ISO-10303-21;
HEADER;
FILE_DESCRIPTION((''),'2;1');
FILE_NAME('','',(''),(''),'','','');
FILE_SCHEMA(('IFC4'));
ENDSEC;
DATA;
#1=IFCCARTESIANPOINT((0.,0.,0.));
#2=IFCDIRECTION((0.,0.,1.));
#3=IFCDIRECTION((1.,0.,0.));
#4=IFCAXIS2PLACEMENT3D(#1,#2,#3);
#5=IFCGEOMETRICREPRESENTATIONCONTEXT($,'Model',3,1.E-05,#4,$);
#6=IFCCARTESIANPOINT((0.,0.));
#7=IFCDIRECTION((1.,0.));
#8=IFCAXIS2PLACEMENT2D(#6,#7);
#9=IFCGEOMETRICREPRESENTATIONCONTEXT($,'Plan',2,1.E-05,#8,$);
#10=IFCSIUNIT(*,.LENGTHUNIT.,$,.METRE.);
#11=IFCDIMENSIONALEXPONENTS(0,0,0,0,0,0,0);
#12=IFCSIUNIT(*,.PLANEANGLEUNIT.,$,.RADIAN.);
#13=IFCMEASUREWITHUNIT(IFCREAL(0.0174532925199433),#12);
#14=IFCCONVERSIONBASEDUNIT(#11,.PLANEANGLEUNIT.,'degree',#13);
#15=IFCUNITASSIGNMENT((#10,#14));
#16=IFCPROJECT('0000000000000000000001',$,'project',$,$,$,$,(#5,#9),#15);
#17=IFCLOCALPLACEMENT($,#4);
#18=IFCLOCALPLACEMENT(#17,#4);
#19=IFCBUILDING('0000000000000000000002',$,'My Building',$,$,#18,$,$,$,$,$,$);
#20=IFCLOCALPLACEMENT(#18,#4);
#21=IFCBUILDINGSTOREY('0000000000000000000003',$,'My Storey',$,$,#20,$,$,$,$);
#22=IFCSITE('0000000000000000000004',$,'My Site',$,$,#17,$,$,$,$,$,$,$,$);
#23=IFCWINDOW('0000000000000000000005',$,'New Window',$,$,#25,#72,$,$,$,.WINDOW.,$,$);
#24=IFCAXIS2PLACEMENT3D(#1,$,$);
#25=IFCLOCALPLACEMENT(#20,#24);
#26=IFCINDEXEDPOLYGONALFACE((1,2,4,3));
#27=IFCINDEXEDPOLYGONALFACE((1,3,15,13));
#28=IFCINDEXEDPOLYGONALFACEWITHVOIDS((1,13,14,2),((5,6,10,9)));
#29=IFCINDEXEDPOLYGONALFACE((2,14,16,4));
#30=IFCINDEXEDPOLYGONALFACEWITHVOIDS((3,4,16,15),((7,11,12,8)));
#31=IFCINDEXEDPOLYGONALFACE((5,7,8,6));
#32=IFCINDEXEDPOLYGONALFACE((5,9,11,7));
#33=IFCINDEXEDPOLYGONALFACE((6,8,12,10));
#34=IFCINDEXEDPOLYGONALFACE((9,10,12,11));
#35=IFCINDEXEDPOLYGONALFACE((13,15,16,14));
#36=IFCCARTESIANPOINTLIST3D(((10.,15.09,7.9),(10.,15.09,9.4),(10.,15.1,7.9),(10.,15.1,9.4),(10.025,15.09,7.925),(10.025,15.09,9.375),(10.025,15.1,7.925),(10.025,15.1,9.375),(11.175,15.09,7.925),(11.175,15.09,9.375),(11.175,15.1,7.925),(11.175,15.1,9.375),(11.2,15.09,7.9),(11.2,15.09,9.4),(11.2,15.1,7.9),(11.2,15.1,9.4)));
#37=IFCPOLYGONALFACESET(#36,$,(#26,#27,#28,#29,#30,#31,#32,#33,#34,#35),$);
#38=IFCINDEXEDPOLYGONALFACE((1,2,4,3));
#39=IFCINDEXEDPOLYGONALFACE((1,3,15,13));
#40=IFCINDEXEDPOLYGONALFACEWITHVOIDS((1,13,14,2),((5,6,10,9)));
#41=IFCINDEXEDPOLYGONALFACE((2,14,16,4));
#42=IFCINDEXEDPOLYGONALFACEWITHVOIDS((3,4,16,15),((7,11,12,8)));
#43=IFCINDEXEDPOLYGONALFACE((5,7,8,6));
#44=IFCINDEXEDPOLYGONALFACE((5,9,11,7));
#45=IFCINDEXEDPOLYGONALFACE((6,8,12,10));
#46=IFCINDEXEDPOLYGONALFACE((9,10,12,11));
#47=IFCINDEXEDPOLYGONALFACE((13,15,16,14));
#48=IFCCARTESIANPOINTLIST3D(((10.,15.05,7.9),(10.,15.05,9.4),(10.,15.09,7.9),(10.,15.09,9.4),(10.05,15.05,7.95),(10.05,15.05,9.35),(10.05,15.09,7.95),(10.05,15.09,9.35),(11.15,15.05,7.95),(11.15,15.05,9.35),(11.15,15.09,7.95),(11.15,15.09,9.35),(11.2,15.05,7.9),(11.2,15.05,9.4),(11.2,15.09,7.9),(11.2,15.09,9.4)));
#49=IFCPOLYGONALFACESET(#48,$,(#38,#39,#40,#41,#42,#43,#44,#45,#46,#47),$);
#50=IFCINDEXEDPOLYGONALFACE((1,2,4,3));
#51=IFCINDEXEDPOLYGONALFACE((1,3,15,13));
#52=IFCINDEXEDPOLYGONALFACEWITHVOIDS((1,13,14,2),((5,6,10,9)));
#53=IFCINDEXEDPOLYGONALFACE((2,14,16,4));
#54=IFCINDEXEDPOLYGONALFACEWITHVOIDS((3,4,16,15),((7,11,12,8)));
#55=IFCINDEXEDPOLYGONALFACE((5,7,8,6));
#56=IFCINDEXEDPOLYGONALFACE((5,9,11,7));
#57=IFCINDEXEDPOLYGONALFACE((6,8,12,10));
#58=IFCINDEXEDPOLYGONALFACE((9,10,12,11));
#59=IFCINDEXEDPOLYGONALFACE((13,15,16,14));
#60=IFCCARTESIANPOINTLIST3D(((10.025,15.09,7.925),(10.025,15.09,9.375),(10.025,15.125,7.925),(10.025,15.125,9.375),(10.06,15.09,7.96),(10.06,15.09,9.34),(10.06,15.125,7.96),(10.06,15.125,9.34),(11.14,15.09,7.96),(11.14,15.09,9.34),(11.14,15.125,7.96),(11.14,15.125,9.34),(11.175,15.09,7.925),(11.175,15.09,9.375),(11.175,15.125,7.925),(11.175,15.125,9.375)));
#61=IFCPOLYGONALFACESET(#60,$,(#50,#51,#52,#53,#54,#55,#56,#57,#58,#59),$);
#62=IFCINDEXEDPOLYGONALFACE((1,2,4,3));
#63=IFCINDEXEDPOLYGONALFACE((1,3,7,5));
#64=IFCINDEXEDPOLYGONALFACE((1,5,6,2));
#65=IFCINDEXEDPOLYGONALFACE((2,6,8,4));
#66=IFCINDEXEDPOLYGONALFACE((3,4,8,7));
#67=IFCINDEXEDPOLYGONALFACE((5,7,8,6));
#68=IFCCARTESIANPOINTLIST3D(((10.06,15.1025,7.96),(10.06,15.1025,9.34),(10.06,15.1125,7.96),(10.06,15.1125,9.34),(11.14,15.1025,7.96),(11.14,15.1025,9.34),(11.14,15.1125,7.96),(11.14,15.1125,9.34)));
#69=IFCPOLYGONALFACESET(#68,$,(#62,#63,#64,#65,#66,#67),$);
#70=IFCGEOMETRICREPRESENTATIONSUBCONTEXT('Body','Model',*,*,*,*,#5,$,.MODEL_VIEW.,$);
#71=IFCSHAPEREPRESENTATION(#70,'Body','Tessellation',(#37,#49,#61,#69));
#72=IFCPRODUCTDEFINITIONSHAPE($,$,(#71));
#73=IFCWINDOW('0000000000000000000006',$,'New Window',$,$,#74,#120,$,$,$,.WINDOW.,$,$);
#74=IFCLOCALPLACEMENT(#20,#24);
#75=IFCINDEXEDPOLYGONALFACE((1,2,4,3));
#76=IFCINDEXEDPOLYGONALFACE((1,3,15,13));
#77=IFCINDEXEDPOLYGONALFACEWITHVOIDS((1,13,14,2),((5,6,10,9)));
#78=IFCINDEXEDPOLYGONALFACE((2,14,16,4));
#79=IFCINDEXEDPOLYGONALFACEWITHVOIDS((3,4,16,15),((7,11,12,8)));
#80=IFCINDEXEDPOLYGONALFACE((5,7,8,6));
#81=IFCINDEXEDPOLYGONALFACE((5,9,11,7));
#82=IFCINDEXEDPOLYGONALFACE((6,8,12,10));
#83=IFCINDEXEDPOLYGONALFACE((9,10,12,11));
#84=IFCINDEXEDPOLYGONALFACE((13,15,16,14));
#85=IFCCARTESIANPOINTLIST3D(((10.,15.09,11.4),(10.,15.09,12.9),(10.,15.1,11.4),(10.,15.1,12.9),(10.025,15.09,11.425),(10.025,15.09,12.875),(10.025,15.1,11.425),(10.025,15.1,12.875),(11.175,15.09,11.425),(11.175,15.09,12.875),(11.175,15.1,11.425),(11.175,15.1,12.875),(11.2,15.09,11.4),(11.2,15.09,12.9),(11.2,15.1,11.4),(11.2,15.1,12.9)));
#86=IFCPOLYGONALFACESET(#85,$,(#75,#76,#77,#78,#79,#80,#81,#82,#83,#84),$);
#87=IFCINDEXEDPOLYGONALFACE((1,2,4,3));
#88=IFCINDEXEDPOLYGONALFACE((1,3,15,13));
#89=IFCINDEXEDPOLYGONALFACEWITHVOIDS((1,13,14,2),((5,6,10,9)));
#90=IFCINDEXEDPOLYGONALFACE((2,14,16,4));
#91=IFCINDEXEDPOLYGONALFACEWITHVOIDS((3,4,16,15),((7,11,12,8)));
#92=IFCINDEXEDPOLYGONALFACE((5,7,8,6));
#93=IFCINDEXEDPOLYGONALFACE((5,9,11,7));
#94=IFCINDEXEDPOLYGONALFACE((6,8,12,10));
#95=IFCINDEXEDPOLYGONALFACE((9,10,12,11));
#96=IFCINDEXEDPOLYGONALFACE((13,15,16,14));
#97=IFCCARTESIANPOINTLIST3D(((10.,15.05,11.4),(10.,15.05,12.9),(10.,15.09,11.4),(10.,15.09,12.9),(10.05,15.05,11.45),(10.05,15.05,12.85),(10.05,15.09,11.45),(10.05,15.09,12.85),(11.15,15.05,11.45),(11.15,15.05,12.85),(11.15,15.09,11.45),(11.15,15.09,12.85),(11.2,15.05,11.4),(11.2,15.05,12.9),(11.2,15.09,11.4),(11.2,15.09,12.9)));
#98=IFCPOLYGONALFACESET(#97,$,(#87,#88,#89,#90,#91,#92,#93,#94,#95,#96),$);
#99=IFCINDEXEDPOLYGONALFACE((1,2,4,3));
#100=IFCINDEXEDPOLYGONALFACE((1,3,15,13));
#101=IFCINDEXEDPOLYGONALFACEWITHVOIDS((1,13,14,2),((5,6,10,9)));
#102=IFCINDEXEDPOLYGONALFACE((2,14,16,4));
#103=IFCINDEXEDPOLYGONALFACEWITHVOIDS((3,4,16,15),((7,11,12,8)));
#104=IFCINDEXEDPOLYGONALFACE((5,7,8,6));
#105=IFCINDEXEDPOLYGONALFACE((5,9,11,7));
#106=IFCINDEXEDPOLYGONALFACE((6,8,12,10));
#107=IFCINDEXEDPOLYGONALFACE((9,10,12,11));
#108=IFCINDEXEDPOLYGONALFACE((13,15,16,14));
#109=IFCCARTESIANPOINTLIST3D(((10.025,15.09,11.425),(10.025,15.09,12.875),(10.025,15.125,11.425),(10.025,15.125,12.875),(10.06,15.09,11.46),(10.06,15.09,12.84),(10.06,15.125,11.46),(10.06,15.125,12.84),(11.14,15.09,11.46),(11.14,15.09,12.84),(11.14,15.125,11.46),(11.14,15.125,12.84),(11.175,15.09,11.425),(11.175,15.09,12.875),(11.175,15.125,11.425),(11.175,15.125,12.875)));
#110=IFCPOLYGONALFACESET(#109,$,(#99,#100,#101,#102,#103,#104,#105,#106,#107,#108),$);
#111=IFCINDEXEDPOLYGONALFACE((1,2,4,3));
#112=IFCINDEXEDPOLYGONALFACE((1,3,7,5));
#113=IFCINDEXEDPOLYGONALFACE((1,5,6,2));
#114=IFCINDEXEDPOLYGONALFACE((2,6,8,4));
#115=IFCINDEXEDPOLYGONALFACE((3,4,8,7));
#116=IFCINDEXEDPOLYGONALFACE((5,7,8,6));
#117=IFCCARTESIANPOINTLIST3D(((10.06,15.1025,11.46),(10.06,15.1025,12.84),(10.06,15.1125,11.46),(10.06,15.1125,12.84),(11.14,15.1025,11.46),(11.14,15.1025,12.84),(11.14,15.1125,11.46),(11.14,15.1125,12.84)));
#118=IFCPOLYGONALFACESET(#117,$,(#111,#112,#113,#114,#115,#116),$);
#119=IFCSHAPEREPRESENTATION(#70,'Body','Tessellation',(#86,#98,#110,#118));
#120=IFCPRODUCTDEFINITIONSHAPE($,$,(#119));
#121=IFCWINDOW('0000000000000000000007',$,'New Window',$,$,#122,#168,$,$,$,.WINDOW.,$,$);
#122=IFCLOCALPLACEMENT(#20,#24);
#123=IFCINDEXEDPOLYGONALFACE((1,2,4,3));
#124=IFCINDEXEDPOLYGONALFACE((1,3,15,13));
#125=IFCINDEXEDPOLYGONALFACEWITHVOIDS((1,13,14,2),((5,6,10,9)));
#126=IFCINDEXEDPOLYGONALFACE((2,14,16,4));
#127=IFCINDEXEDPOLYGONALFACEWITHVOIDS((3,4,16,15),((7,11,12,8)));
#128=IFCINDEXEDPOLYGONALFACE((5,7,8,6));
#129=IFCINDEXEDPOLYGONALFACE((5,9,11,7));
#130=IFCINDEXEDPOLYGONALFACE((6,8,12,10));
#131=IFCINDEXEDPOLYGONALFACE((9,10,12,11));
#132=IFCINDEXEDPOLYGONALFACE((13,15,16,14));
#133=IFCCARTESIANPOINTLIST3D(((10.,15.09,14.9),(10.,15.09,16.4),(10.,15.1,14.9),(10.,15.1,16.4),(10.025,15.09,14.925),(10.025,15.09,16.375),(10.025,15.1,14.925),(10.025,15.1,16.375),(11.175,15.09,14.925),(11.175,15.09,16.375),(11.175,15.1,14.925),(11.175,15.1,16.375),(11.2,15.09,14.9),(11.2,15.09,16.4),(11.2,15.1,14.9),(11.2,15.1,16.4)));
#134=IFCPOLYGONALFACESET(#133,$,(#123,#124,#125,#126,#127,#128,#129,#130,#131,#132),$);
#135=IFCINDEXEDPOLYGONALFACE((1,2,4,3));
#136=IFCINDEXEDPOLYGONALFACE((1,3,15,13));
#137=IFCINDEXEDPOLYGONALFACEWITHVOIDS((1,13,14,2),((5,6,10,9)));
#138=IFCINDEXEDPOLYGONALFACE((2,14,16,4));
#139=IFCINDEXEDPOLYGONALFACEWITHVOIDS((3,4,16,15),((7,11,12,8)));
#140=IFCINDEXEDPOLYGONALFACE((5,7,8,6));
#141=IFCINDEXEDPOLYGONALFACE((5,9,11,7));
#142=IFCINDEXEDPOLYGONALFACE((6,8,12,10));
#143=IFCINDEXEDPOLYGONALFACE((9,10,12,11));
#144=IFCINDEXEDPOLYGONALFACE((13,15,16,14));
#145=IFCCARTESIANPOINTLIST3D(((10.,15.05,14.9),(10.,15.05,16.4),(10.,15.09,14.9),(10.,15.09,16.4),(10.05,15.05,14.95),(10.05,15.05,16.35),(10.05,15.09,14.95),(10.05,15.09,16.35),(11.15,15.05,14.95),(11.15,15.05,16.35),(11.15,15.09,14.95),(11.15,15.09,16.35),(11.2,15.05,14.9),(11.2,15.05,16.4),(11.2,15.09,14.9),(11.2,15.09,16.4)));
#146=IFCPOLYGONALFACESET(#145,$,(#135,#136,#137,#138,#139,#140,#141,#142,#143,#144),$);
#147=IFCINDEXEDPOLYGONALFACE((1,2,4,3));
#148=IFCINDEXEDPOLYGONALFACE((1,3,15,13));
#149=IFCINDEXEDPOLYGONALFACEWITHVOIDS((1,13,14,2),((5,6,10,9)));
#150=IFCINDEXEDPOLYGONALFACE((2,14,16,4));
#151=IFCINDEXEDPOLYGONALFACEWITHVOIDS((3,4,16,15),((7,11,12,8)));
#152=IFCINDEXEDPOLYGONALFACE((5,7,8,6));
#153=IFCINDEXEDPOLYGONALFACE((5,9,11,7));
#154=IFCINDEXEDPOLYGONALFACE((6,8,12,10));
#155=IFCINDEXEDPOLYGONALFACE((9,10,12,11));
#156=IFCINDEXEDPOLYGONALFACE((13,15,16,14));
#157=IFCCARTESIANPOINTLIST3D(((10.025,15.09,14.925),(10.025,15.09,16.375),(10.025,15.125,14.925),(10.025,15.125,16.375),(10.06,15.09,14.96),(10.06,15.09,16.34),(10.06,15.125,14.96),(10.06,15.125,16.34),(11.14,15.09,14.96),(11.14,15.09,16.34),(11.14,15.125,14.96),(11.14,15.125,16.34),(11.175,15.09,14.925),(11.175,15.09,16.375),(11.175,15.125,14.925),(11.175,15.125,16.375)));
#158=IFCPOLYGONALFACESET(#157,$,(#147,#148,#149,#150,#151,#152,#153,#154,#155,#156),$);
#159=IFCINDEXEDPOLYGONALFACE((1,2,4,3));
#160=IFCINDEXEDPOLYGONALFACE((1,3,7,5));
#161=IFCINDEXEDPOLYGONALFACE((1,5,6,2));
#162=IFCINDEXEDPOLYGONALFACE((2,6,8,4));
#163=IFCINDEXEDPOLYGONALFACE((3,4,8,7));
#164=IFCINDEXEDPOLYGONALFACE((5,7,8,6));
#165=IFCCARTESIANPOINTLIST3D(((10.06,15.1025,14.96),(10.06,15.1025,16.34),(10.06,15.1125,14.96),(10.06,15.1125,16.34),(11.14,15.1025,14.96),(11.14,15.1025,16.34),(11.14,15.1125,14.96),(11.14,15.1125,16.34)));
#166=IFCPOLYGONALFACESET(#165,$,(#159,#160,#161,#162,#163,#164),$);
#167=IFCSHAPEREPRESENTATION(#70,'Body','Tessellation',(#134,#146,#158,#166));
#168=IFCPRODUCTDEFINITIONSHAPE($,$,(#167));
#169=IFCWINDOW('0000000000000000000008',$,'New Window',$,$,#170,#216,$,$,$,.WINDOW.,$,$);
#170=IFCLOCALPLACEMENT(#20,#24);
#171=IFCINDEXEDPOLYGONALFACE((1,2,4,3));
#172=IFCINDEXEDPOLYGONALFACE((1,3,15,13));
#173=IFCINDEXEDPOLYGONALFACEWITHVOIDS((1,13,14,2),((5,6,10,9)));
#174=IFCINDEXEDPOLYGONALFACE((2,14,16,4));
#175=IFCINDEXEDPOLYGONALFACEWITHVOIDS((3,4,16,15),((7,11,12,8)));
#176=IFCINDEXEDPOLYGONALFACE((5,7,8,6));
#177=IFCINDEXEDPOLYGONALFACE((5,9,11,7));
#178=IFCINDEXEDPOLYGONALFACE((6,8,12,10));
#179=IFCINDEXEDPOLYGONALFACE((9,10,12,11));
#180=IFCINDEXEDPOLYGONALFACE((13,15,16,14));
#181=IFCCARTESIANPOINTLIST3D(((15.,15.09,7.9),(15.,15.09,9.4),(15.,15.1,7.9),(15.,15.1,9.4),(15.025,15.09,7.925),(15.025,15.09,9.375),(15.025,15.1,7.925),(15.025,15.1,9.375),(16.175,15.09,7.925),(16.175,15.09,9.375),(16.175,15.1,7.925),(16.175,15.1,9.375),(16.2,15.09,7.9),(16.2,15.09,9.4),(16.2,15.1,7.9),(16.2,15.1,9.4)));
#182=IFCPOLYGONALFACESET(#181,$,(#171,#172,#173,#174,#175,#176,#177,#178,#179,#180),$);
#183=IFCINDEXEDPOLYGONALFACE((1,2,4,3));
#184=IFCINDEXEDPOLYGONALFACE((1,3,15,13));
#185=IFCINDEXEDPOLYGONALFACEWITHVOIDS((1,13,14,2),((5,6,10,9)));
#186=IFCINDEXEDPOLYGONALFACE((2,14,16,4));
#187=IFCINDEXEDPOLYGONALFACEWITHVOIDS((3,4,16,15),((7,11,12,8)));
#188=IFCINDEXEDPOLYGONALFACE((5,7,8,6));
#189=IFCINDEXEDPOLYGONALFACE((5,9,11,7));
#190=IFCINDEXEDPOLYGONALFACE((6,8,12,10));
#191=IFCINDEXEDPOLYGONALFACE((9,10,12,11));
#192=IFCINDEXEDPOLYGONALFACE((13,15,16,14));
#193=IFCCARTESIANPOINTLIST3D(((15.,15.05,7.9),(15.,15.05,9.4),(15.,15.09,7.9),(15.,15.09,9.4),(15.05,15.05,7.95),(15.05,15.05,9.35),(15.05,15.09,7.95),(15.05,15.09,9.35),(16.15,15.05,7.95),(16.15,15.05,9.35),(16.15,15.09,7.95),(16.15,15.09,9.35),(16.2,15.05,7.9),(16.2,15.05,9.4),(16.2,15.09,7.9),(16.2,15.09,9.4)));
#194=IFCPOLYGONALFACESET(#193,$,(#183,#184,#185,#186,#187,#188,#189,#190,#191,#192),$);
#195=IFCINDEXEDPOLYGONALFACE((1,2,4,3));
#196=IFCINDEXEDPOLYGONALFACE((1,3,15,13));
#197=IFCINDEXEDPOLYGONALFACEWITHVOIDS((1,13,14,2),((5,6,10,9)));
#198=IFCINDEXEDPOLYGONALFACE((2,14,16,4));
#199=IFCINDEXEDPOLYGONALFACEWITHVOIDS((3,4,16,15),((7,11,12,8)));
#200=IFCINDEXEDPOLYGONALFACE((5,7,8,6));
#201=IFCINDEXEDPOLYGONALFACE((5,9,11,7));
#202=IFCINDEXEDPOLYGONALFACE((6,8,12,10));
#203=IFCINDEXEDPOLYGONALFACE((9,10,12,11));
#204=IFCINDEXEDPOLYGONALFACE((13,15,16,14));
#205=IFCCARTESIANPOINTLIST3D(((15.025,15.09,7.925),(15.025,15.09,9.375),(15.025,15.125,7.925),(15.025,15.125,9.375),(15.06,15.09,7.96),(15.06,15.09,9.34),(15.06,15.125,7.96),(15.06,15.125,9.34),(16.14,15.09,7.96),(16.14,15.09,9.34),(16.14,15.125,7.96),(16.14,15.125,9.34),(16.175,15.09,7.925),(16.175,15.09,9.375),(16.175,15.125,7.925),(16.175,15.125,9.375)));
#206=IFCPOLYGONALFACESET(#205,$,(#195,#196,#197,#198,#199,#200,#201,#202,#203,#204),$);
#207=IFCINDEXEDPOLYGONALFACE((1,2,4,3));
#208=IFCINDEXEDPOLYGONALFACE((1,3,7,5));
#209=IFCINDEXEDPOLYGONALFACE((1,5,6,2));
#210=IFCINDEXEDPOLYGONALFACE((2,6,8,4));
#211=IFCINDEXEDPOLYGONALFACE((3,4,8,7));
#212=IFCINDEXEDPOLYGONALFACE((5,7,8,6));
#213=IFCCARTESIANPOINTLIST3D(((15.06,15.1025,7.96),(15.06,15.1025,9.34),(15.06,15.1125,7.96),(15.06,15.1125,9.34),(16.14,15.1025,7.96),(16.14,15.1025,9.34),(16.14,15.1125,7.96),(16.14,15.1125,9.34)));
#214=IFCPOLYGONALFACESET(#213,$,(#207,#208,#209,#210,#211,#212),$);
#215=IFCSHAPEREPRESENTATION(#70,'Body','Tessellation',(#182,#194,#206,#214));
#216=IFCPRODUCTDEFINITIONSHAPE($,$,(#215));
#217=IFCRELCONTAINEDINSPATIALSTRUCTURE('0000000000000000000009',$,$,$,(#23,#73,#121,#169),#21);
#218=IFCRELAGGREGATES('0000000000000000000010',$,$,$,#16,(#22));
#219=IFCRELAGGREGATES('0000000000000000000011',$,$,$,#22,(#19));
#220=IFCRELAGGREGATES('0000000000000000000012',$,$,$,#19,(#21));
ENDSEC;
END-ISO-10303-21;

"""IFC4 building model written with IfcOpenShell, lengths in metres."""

from ifc_helpers import new_model, entity, si_unit, converted_unit, frame, origin_with_axes, origin_2d_with_axis, place, context, subcontext, project, spatial, line, indexed_curve, outline, extrude, element, save


model = new_model("IFC4")

# Units and contexts
model_context = context("Model", 3, precision=1e-05, world=origin_with_axes())
plan_context = context("Plan", 2, precision=1e-05, world=origin_2d_with_axis())
body_context = subcontext(model_context, "Body", "Model", "MODEL_VIEW")
ifc_project = project(units=[si_unit("LENGTHUNIT", "METRE"), converted_unit("PLANEANGLEUNIT", "degree", entity("IfcReal", 0.0174532925199433), si_unit("PLANEANGLEUNIT", "RADIAN"), dimensions=[0, 0, 0, 0, 0, 0, 0])], contexts=[model_context, plan_context])

# Site, building, storey
site_placement = place(None, origin_with_axes())
site = spatial("IfcSite", under=ifc_project, at=site_placement, Name="My Site")
building_placement = place(site_placement, origin_with_axes())
building = spatial("IfcBuilding", under=site, at=building_placement, Name="My Building")
storey_placement = place(building_placement, origin_with_axes())
storey = spatial("IfcBuildingStorey", under=building, at=storey_placement, Name="My Storey")

# Windows
for number, where, z_axis, x_axis, name in (
    (1, (10.0, 15.0, 7.9), (0.0, 0.0, 1.0), (1.0, 0.0, 0.0), "New Window"),
    (2, (10.0, 15.0, 11.4), (0.0, 0.0, 1.0), (1.0, 0.0, 0.0), "New Window"),
    (3, (10.0, 15.0, 14.9), (0.0, 0.0, 1.0), (1.0, 0.0, 0.0), "New Window"),
    (4, (15.0, 15.0, 7.9), (0.0, 0.0, 1.0), (1.0, 0.0, 0.0), "New Window"),
):
    element("IfcWindow", number, at=place(storey_placement, frame(where, z_axis=z_axis, x_axis=x_axis)), inside=storey, Name=name, PredefinedType="WINDOW", context=body_context, shape_type="SweptSolid", body=[
        extrude(outline(indexed_curve([(0.0, 0.0), (1.2, 0.0), (1.2, 1.5), (0.0, 1.5)], segments=[line(1, 2, 3, 4, 1)]), holes=[indexed_curve([(0.025, 0.025), (1.175, 0.025), (1.175, 1.475), (0.025, 1.475)], segments=[line(1, 2, 3, 4, 1)])]), frame((0.0, 0.09, 0.0), z_axis=(0.0, -1.0, 0.0), x_axis=(1.0, 0.0, 0.0)), (0.0, 0.0, -1.0), 0.01),
        extrude(outline(indexed_curve([(0.0, 0.0), (1.2, 0.0), (1.2, 1.5), (0.0, 1.5)], segments=[line(1, 2, 3, 4, 1)]), holes=[indexed_curve([(0.05, 0.05), (1.15, 0.05), (1.15, 1.45), (0.05, 1.45)], segments=[line(1, 2, 3, 4, 1)])]), frame((0.0, 0.05, 0.0), z_axis=(0.0, -1.0, 0.0), x_axis=(1.0, 0.0, 0.0)), (0.0, 0.0, -1.0), 0.04),
        extrude(outline(indexed_curve([(0.0, 0.0), (1.15, 0.0), (1.15, 1.45), (0.0, 1.45)], segments=[line(1, 2, 3, 4, 1)]), holes=[indexed_curve([(0.035, 0.035), (1.115, 0.035), (1.115, 1.415), (0.035, 1.415)], segments=[line(1, 2, 3, 4, 1)])]), frame((0.025, 0.09, 0.025), z_axis=(0.0, -1.0, 0.0), x_axis=(1.0, 0.0, 0.0)), (0.0, 0.0, -1.0), 0.035),
        extrude(outline(indexed_curve([(0.035, 0.035), (1.115, 0.035), (1.115, 1.415), (0.035, 1.415)], segments=[line(1, 2, 3, 4, 1)])), frame((0.025, 0.1025, 0.025), z_axis=(0.0, -1.0, 0.0), x_axis=(1.0, 0.0, 0.0)), (0.0, 0.0, -1.0), 0.01),
    ])

save(model, "model.ifc")
